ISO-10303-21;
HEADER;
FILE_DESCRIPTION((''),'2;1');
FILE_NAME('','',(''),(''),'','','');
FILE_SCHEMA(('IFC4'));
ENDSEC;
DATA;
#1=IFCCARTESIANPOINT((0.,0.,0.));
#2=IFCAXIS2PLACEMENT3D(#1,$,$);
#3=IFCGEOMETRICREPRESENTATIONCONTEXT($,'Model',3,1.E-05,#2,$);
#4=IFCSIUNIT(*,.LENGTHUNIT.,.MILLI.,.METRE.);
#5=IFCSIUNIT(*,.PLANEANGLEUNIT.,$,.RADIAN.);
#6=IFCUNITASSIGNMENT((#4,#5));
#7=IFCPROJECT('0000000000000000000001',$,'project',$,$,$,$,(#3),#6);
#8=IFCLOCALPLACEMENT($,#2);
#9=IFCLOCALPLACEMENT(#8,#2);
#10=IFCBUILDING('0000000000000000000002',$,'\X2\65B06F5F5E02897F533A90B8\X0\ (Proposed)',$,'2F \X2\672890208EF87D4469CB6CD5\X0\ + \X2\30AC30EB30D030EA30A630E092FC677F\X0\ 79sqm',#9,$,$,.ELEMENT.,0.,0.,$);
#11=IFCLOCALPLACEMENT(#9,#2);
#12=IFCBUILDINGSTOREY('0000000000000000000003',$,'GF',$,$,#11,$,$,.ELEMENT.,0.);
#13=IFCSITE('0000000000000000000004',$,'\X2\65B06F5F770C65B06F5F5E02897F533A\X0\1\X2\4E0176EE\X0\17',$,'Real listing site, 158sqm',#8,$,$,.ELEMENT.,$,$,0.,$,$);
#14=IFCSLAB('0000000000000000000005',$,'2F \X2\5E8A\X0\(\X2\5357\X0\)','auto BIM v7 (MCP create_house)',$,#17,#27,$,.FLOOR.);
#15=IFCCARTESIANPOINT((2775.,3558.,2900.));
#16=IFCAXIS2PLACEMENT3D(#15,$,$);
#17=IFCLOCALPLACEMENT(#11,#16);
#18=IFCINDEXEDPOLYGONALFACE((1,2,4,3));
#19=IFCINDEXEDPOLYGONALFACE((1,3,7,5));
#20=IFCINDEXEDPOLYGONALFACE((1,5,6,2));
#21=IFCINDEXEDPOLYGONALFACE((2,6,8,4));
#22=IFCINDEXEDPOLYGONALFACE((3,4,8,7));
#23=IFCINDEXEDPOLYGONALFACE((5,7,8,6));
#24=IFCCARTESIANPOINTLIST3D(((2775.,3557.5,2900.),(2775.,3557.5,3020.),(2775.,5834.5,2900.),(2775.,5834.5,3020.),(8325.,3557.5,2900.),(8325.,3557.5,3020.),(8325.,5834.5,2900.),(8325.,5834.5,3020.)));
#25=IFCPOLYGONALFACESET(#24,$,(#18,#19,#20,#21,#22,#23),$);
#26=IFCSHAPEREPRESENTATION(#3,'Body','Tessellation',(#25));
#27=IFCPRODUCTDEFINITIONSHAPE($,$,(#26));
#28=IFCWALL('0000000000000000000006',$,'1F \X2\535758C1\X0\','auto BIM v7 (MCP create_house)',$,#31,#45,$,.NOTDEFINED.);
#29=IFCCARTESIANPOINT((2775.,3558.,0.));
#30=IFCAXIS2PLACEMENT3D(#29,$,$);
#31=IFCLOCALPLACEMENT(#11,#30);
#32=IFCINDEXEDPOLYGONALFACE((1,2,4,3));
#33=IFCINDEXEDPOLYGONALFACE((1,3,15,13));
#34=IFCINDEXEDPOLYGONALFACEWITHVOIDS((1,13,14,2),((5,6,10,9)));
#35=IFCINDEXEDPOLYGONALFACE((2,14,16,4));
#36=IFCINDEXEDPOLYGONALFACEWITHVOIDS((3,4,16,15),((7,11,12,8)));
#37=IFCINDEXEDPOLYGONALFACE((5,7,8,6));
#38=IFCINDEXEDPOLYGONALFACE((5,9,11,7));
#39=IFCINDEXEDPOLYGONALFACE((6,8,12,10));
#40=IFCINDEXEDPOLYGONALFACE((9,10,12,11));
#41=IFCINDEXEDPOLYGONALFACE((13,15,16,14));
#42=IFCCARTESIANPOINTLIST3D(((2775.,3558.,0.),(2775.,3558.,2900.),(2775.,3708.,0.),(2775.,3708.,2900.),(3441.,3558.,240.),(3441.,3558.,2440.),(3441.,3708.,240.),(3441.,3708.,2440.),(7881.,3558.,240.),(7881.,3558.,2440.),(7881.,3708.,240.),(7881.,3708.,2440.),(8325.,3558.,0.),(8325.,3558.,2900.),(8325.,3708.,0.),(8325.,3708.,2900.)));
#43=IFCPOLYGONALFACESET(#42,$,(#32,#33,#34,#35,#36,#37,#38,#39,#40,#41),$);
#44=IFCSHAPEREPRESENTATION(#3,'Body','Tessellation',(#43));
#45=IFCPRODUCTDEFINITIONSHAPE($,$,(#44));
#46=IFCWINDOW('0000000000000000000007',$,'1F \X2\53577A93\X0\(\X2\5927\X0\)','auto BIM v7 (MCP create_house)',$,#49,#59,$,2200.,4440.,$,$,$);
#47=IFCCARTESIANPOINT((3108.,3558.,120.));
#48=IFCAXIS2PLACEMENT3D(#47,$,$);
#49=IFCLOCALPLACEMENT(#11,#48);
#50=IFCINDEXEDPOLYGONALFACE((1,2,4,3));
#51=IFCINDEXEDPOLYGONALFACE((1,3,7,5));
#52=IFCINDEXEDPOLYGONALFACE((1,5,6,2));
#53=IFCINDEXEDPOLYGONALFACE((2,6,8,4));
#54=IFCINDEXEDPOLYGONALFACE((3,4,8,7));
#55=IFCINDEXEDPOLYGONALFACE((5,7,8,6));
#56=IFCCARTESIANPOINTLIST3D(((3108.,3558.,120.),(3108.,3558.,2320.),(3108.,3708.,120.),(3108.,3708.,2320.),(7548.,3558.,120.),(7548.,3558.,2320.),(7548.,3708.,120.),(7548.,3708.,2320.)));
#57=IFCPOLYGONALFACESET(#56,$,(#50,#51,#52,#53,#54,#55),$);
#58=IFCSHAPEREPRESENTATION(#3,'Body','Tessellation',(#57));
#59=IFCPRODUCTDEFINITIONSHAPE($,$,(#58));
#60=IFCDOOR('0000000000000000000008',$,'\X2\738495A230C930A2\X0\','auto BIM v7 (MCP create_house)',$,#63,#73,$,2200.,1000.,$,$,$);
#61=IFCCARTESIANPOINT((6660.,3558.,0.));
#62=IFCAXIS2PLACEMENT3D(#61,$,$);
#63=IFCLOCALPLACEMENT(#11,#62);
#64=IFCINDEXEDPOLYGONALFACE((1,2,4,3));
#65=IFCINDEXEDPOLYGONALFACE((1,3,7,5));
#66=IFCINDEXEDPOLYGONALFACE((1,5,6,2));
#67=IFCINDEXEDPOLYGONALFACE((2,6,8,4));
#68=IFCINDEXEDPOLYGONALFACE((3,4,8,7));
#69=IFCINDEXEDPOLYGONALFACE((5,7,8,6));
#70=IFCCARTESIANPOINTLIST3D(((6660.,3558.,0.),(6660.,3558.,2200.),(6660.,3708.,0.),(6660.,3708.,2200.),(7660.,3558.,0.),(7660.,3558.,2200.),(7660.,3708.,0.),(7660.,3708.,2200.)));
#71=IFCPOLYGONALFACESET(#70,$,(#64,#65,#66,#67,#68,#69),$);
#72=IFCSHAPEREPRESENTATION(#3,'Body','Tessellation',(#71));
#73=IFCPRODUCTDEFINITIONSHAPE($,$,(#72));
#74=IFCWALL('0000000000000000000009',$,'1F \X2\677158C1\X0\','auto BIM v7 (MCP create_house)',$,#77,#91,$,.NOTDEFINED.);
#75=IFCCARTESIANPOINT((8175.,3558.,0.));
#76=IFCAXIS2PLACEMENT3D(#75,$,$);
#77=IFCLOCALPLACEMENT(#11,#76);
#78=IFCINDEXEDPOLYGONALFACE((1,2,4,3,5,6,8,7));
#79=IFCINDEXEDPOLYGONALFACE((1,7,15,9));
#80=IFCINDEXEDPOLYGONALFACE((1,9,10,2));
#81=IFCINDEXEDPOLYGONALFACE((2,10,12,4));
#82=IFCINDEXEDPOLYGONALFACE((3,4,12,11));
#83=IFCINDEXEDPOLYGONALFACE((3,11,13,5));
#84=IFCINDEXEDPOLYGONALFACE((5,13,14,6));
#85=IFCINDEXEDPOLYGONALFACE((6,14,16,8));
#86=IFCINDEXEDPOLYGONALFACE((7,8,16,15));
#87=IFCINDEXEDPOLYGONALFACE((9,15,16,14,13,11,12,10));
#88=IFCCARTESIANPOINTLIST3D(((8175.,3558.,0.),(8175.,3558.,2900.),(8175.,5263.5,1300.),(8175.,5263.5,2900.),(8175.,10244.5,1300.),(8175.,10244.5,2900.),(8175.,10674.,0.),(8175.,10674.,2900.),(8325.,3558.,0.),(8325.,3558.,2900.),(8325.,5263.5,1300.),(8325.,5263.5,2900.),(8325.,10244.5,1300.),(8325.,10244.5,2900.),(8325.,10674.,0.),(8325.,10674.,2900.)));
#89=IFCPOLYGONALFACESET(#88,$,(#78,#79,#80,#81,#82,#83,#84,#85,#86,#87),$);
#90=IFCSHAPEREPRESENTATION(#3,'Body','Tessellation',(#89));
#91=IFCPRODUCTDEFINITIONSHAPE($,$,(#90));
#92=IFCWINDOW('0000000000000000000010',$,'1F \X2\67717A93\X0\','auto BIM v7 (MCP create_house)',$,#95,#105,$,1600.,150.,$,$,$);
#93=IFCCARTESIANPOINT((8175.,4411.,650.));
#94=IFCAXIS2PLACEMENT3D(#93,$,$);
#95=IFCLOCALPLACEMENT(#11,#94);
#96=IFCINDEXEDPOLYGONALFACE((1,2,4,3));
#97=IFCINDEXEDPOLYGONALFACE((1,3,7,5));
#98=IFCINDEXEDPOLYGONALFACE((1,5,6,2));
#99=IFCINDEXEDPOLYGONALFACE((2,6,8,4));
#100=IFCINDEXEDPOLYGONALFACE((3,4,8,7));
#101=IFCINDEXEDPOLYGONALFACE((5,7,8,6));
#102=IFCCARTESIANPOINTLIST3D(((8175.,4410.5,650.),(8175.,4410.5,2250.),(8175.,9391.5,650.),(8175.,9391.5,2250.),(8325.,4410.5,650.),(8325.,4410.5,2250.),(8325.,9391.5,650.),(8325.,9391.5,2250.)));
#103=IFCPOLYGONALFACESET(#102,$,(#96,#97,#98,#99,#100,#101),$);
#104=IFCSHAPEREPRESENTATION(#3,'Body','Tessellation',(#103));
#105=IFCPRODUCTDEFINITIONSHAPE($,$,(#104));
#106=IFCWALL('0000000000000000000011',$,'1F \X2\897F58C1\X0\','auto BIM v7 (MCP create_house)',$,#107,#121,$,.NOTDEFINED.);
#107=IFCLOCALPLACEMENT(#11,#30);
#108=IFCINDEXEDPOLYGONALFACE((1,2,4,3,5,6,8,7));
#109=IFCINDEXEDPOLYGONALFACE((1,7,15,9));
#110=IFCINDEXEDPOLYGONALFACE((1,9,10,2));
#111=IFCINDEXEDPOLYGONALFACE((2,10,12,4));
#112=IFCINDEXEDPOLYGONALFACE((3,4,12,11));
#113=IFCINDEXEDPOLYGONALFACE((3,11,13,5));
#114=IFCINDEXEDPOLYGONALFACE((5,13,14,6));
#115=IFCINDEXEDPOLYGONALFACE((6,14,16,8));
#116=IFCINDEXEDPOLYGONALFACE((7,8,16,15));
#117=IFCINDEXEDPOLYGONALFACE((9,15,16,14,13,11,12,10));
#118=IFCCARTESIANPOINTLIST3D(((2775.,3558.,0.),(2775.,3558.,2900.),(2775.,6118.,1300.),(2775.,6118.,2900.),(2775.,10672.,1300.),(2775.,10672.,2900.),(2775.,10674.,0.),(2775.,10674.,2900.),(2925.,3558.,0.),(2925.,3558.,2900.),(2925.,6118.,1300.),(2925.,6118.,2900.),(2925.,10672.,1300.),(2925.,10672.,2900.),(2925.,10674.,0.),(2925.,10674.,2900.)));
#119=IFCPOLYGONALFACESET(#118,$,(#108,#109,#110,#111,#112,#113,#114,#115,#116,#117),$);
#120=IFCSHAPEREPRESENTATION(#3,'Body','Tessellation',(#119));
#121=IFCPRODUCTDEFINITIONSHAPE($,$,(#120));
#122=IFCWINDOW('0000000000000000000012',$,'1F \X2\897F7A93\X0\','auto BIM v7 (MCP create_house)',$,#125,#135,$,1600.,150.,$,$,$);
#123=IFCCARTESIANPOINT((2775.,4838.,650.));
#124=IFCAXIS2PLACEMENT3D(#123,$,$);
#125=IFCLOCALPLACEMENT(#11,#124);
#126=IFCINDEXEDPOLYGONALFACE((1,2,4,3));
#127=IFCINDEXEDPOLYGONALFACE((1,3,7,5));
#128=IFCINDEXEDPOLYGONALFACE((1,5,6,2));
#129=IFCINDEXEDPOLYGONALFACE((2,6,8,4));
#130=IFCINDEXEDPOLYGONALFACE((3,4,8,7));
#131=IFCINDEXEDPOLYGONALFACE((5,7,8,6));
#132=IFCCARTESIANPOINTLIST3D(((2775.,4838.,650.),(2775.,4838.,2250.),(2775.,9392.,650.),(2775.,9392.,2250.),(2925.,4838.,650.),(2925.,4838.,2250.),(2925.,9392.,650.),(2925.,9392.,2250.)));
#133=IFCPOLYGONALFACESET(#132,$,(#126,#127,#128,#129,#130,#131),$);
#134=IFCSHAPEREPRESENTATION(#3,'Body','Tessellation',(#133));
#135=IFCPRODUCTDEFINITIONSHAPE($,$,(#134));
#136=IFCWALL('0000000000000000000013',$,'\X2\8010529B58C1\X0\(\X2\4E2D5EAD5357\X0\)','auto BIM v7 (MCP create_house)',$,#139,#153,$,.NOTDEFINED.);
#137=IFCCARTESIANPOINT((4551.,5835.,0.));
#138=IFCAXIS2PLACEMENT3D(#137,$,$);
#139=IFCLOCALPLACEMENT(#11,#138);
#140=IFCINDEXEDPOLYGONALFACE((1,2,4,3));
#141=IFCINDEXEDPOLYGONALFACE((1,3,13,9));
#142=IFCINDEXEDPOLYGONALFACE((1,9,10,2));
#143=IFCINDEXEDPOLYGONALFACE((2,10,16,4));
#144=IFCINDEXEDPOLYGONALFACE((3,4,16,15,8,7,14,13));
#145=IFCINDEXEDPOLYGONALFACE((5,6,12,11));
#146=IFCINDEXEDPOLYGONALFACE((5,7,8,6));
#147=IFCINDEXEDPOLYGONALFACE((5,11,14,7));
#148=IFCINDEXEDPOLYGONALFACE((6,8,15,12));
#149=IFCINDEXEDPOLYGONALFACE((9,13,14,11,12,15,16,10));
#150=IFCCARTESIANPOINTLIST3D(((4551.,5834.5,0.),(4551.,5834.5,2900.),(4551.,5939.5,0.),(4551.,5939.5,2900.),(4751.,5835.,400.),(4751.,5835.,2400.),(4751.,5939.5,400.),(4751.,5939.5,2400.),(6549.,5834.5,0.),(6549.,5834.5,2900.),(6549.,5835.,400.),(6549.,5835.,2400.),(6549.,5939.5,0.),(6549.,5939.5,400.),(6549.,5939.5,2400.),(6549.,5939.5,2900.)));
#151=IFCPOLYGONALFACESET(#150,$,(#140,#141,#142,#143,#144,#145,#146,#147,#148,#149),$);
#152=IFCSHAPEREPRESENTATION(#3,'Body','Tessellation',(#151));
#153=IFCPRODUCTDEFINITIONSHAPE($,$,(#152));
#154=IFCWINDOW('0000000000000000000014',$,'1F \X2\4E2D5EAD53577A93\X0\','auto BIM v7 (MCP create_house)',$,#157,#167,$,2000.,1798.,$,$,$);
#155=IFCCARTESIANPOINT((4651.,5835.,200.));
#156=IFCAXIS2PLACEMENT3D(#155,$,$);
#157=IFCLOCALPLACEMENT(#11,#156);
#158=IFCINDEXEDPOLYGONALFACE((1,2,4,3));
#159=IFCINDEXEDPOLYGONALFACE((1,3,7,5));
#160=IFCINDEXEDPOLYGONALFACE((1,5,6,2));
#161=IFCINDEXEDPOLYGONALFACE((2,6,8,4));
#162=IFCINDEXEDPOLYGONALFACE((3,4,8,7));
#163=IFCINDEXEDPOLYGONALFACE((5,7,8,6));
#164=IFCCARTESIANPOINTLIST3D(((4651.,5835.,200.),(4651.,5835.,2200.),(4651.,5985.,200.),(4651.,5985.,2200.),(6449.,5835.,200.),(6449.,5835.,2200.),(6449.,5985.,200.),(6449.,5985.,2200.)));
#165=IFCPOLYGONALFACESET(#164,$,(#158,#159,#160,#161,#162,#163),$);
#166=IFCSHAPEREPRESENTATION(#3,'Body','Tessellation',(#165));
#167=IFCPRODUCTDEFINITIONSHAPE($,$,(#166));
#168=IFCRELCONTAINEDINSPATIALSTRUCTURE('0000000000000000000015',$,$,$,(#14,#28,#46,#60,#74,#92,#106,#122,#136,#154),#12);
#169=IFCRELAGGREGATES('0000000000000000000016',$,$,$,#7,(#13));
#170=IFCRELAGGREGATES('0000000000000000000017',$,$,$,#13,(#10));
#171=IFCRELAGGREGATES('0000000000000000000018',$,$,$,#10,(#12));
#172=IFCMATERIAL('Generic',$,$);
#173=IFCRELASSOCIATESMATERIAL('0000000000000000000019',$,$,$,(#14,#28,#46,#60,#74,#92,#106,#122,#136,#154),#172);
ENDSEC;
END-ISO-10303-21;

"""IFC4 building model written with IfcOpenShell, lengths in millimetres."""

from ifc_helpers import new_model, si_unit, frame, frame_2d, origin, place, context, project, spatial, rectangle, extrude, material, element, fill, save


model = new_model("IFC4")

# Units and contexts
model_context = context("Model", 3, precision=1e-05, world=origin())
ifc_project = project(units=[si_unit("LENGTHUNIT", "METRE", prefix="MILLI"), si_unit("PLANEANGLEUNIT", "RADIAN")], contexts=[model_context])

# Site, building, storey
site_placement = place(None, origin())
site = spatial("IfcSite", under=ifc_project, at=site_placement, Name="新潟県新潟市西区1丁目17", ObjectType="Real listing site, 158sqm", CompositionType="ELEMENT", RefElevation=0.0)
building_placement = place(site_placement, origin())
building = spatial("IfcBuilding", under=site, at=building_placement, Name="新潟市西区邸 (Proposed)", ObjectType="2F 木造軸組構法 + ガルバリウム鋼板 79sqm", CompositionType="ELEMENT", ElevationOfRefHeight=0.0, ElevationOfTerrain=0.0)
storey_placement = place(building_placement, origin())
storey = spatial("IfcBuildingStorey", under=building, at=storey_placement, Name="GF", CompositionType="ELEMENT", Elevation=0.0)

# Slab
ifc_material = material(Name="Generic")
slab_1_placement = place(storey_placement, frame((2775.0, 3558.0, 2900.0)))
element("IfcSlab", 1, at=slab_1_placement, inside=storey, material=ifc_material, Name="2F 床(南)", Description="auto BIM v7 (MCP create_house)", PredefinedType="FLOOR", context=model_context, shape_type="SweptSolid", body=[
    extrude(rectangle(XDim=5550.0, YDim=2277.0, at=frame_2d((2775.0, 1138.0))), frame((2775.0, 3558.0, 2900.0)), (0.0, 0.0, 1.0), 120.0),
])

# Wall, openings, window, door
wall_1_placement = place(storey_placement, frame((2775.0, 3558.0, 0.0)))
wall_1 = element("IfcWall", 2, at=wall_1_placement, inside=storey, material=ifc_material, Name="1F 南壁", Description="auto BIM v7 (MCP create_house)", PredefinedType="NOTDEFINED", context=model_context, shape_type="SweptSolid", body=[
    extrude(rectangle(XDim=5550.0, YDim=150.0, at=frame_2d((2775.0, 75.0))), frame((2775.0, 3558.0, 0.0)), (0.0, 0.0, 1.0), 2900.0),
])
opening_1_placement = place(storey_placement, frame((3108.0, 3558.0, 120.0)))
opening_1 = element("IfcOpeningElement", 3, at=opening_1_placement, cuts=wall_1, PredefinedType="NOTDEFINED", context=model_context, shape_type="SweptSolid", body=[
    extrude(rectangle(XDim=4440.0, YDim=150.0, at=frame_2d((2220.0, 75.0))), frame((3108.0, 3558.0, 120.0)), (0.0, 0.0, 1.0), 2200.0),
])
opening_2_placement = place(storey_placement, frame((6660.0, 3558.0, 0.0)))
opening_2 = element("IfcOpeningElement", 4, at=opening_2_placement, cuts=wall_1, PredefinedType="NOTDEFINED", context=model_context, shape_type="SweptSolid", body=[
    extrude(rectangle(XDim=1000.0, YDim=150.0, at=frame_2d((500.0, 75.0))), frame((6660.0, 3558.0, 0.0)), (0.0, 0.0, 1.0), 2200.0),
])
window_1_placement = place(storey_placement, frame((3108.0, 3558.0, 120.0)))
window_1 = element("IfcWindow", 5, at=window_1_placement, inside=storey, material=ifc_material, Name="1F 南窓(大)", Description="auto BIM v7 (MCP create_house)", OverallHeight=2200.0, OverallWidth=4440.0, context=model_context, shape_type="SweptSolid", body=[
    extrude(rectangle(XDim=4440.0, YDim=150.0, at=frame_2d((2220.0, 75.0))), frame((3108.0, 3558.0, 120.0)), (0.0, 0.0, 1.0), 2200.0),
])
fill(opening_1, window_1)
door_placement = place(storey_placement, frame((6660.0, 3558.0, 0.0)))
door = element("IfcDoor", 6, at=door_placement, inside=storey, material=ifc_material, Name="玄関ドア", Description="auto BIM v7 (MCP create_house)", OverallHeight=2200.0, OverallWidth=1000.0, context=model_context, shape_type="SweptSolid", body=[
    extrude(rectangle(XDim=1000.0, YDim=150.0, at=frame_2d((500.0, 75.0))), frame((6660.0, 3558.0, 0.0)), (0.0, 0.0, 1.0), 2200.0),
])
fill(opening_2, door)

# Walls, openings, windows
wall_2_placement = place(storey_placement, frame((8175.0, 3558.0, 0.0)))
wall_2 = element("IfcWall", 7, at=wall_2_placement, inside=storey, material=ifc_material, Name="1F 東壁", Description="auto BIM v7 (MCP create_house)", PredefinedType="NOTDEFINED", context=model_context, shape_type="SweptSolid", body=[
    extrude(rectangle(XDim=150.0, YDim=7116.0, at=frame_2d((75.0, 3558.0))), frame((8175.0, 3558.0, 0.0)), (0.0, 0.0, 1.0), 2900.0),
])
opening_3_placement = place(storey_placement, frame((8175.0, 4411.0, 650.0)))
opening_3 = element("IfcOpeningElement", 8, at=opening_3_placement, cuts=wall_2, PredefinedType="NOTDEFINED", context=model_context, shape_type="SweptSolid", body=[
    extrude(rectangle(XDim=150.0, YDim=4981.0, at=frame_2d((75.0, 2490.0))), frame((8175.0, 4411.0, 650.0)), (0.0, 0.0, 1.0), 1600.0),
])
window_2_placement = place(storey_placement, frame((8175.0, 4411.0, 650.0)))
window_2 = element("IfcWindow", 9, at=window_2_placement, inside=storey, material=ifc_material, Name="1F 東窓", Description="auto BIM v7 (MCP create_house)", OverallHeight=1600.0, OverallWidth=150.0, context=model_context, shape_type="SweptSolid", body=[
    extrude(rectangle(XDim=150.0, YDim=4981.0, at=frame_2d((75.0, 2490.0))), frame((8175.0, 4411.0, 650.0)), (0.0, 0.0, 1.0), 1600.0),
])
fill(opening_3, window_2)
wall_3_placement = place(storey_placement, frame((2775.0, 3558.0, 0.0)))
wall_3 = element("IfcWall", 10, at=wall_3_placement, inside=storey, material=ifc_material, Name="1F 西壁", Description="auto BIM v7 (MCP create_house)", PredefinedType="NOTDEFINED", context=model_context, shape_type="SweptSolid", body=[
    extrude(rectangle(XDim=150.0, YDim=7116.0, at=frame_2d((75.0, 3558.0))), frame((2775.0, 3558.0, 0.0)), (0.0, 0.0, 1.0), 2900.0),
])
opening_4_placement = place(storey_placement, frame((2775.0, 4838.0, 650.0)))
opening_4 = element("IfcOpeningElement", 11, at=opening_4_placement, cuts=wall_3, PredefinedType="NOTDEFINED", context=model_context, shape_type="SweptSolid", body=[
    extrude(rectangle(XDim=150.0, YDim=4554.0, at=frame_2d((75.0, 2277.0))), frame((2775.0, 4838.0, 650.0)), (0.0, 0.0, 1.0), 1600.0),
])
window_3_placement = place(storey_placement, frame((2775.0, 4838.0, 650.0)))
window_3 = element("IfcWindow", 12, at=window_3_placement, inside=storey, material=ifc_material, Name="1F 西窓", Description="auto BIM v7 (MCP create_house)", OverallHeight=1600.0, OverallWidth=150.0, context=model_context, shape_type="SweptSolid", body=[
    extrude(rectangle(XDim=150.0, YDim=4554.0, at=frame_2d((75.0, 2277.0))), frame((2775.0, 4838.0, 650.0)), (0.0, 0.0, 1.0), 1600.0),
])
fill(opening_4, window_3)
wall_4_placement = place(storey_placement, frame((4551.0, 5835.0, 0.0)))
wall_4 = element("IfcWall", 13, at=wall_4_placement, inside=storey, material=ifc_material, Name="耐力壁(中庭南)", Description="auto BIM v7 (MCP create_house)", PredefinedType="NOTDEFINED", context=model_context, shape_type="SweptSolid", body=[
    extrude(rectangle(XDim=1998.0, YDim=105.0, at=frame_2d((999.0, 52.0))), frame((4551.0, 5835.0, 0.0)), (0.0, 0.0, 1.0), 2900.0),
])
opening_5_placement = place(storey_placement, frame((4651.0, 5835.0, 200.0)))
opening_5 = element("IfcOpeningElement", 14, at=opening_5_placement, cuts=wall_4, PredefinedType="NOTDEFINED", context=model_context, shape_type="SweptSolid", body=[
    extrude(rectangle(XDim=1798.0, YDim=150.0, at=frame_2d((899.0, 75.0))), frame((4651.0, 5835.0, 200.0)), (0.0, 0.0, 1.0), 2000.0),
])
window_4_placement = place(storey_placement, frame((4651.0, 5835.0, 200.0)))
window_4 = element("IfcWindow", 15, at=window_4_placement, inside=storey, material=ifc_material, Name="1F 中庭南窓", Description="auto BIM v7 (MCP create_house)", OverallHeight=2000.0, OverallWidth=1798.0, context=model_context, shape_type="SweptSolid", body=[
    extrude(rectangle(XDim=1798.0, YDim=150.0, at=frame_2d((899.0, 75.0))), frame((4651.0, 5835.0, 200.0)), (0.0, 0.0, 1.0), 2000.0),
])
fill(opening_5, window_4)

save(model, "model.ifc")
